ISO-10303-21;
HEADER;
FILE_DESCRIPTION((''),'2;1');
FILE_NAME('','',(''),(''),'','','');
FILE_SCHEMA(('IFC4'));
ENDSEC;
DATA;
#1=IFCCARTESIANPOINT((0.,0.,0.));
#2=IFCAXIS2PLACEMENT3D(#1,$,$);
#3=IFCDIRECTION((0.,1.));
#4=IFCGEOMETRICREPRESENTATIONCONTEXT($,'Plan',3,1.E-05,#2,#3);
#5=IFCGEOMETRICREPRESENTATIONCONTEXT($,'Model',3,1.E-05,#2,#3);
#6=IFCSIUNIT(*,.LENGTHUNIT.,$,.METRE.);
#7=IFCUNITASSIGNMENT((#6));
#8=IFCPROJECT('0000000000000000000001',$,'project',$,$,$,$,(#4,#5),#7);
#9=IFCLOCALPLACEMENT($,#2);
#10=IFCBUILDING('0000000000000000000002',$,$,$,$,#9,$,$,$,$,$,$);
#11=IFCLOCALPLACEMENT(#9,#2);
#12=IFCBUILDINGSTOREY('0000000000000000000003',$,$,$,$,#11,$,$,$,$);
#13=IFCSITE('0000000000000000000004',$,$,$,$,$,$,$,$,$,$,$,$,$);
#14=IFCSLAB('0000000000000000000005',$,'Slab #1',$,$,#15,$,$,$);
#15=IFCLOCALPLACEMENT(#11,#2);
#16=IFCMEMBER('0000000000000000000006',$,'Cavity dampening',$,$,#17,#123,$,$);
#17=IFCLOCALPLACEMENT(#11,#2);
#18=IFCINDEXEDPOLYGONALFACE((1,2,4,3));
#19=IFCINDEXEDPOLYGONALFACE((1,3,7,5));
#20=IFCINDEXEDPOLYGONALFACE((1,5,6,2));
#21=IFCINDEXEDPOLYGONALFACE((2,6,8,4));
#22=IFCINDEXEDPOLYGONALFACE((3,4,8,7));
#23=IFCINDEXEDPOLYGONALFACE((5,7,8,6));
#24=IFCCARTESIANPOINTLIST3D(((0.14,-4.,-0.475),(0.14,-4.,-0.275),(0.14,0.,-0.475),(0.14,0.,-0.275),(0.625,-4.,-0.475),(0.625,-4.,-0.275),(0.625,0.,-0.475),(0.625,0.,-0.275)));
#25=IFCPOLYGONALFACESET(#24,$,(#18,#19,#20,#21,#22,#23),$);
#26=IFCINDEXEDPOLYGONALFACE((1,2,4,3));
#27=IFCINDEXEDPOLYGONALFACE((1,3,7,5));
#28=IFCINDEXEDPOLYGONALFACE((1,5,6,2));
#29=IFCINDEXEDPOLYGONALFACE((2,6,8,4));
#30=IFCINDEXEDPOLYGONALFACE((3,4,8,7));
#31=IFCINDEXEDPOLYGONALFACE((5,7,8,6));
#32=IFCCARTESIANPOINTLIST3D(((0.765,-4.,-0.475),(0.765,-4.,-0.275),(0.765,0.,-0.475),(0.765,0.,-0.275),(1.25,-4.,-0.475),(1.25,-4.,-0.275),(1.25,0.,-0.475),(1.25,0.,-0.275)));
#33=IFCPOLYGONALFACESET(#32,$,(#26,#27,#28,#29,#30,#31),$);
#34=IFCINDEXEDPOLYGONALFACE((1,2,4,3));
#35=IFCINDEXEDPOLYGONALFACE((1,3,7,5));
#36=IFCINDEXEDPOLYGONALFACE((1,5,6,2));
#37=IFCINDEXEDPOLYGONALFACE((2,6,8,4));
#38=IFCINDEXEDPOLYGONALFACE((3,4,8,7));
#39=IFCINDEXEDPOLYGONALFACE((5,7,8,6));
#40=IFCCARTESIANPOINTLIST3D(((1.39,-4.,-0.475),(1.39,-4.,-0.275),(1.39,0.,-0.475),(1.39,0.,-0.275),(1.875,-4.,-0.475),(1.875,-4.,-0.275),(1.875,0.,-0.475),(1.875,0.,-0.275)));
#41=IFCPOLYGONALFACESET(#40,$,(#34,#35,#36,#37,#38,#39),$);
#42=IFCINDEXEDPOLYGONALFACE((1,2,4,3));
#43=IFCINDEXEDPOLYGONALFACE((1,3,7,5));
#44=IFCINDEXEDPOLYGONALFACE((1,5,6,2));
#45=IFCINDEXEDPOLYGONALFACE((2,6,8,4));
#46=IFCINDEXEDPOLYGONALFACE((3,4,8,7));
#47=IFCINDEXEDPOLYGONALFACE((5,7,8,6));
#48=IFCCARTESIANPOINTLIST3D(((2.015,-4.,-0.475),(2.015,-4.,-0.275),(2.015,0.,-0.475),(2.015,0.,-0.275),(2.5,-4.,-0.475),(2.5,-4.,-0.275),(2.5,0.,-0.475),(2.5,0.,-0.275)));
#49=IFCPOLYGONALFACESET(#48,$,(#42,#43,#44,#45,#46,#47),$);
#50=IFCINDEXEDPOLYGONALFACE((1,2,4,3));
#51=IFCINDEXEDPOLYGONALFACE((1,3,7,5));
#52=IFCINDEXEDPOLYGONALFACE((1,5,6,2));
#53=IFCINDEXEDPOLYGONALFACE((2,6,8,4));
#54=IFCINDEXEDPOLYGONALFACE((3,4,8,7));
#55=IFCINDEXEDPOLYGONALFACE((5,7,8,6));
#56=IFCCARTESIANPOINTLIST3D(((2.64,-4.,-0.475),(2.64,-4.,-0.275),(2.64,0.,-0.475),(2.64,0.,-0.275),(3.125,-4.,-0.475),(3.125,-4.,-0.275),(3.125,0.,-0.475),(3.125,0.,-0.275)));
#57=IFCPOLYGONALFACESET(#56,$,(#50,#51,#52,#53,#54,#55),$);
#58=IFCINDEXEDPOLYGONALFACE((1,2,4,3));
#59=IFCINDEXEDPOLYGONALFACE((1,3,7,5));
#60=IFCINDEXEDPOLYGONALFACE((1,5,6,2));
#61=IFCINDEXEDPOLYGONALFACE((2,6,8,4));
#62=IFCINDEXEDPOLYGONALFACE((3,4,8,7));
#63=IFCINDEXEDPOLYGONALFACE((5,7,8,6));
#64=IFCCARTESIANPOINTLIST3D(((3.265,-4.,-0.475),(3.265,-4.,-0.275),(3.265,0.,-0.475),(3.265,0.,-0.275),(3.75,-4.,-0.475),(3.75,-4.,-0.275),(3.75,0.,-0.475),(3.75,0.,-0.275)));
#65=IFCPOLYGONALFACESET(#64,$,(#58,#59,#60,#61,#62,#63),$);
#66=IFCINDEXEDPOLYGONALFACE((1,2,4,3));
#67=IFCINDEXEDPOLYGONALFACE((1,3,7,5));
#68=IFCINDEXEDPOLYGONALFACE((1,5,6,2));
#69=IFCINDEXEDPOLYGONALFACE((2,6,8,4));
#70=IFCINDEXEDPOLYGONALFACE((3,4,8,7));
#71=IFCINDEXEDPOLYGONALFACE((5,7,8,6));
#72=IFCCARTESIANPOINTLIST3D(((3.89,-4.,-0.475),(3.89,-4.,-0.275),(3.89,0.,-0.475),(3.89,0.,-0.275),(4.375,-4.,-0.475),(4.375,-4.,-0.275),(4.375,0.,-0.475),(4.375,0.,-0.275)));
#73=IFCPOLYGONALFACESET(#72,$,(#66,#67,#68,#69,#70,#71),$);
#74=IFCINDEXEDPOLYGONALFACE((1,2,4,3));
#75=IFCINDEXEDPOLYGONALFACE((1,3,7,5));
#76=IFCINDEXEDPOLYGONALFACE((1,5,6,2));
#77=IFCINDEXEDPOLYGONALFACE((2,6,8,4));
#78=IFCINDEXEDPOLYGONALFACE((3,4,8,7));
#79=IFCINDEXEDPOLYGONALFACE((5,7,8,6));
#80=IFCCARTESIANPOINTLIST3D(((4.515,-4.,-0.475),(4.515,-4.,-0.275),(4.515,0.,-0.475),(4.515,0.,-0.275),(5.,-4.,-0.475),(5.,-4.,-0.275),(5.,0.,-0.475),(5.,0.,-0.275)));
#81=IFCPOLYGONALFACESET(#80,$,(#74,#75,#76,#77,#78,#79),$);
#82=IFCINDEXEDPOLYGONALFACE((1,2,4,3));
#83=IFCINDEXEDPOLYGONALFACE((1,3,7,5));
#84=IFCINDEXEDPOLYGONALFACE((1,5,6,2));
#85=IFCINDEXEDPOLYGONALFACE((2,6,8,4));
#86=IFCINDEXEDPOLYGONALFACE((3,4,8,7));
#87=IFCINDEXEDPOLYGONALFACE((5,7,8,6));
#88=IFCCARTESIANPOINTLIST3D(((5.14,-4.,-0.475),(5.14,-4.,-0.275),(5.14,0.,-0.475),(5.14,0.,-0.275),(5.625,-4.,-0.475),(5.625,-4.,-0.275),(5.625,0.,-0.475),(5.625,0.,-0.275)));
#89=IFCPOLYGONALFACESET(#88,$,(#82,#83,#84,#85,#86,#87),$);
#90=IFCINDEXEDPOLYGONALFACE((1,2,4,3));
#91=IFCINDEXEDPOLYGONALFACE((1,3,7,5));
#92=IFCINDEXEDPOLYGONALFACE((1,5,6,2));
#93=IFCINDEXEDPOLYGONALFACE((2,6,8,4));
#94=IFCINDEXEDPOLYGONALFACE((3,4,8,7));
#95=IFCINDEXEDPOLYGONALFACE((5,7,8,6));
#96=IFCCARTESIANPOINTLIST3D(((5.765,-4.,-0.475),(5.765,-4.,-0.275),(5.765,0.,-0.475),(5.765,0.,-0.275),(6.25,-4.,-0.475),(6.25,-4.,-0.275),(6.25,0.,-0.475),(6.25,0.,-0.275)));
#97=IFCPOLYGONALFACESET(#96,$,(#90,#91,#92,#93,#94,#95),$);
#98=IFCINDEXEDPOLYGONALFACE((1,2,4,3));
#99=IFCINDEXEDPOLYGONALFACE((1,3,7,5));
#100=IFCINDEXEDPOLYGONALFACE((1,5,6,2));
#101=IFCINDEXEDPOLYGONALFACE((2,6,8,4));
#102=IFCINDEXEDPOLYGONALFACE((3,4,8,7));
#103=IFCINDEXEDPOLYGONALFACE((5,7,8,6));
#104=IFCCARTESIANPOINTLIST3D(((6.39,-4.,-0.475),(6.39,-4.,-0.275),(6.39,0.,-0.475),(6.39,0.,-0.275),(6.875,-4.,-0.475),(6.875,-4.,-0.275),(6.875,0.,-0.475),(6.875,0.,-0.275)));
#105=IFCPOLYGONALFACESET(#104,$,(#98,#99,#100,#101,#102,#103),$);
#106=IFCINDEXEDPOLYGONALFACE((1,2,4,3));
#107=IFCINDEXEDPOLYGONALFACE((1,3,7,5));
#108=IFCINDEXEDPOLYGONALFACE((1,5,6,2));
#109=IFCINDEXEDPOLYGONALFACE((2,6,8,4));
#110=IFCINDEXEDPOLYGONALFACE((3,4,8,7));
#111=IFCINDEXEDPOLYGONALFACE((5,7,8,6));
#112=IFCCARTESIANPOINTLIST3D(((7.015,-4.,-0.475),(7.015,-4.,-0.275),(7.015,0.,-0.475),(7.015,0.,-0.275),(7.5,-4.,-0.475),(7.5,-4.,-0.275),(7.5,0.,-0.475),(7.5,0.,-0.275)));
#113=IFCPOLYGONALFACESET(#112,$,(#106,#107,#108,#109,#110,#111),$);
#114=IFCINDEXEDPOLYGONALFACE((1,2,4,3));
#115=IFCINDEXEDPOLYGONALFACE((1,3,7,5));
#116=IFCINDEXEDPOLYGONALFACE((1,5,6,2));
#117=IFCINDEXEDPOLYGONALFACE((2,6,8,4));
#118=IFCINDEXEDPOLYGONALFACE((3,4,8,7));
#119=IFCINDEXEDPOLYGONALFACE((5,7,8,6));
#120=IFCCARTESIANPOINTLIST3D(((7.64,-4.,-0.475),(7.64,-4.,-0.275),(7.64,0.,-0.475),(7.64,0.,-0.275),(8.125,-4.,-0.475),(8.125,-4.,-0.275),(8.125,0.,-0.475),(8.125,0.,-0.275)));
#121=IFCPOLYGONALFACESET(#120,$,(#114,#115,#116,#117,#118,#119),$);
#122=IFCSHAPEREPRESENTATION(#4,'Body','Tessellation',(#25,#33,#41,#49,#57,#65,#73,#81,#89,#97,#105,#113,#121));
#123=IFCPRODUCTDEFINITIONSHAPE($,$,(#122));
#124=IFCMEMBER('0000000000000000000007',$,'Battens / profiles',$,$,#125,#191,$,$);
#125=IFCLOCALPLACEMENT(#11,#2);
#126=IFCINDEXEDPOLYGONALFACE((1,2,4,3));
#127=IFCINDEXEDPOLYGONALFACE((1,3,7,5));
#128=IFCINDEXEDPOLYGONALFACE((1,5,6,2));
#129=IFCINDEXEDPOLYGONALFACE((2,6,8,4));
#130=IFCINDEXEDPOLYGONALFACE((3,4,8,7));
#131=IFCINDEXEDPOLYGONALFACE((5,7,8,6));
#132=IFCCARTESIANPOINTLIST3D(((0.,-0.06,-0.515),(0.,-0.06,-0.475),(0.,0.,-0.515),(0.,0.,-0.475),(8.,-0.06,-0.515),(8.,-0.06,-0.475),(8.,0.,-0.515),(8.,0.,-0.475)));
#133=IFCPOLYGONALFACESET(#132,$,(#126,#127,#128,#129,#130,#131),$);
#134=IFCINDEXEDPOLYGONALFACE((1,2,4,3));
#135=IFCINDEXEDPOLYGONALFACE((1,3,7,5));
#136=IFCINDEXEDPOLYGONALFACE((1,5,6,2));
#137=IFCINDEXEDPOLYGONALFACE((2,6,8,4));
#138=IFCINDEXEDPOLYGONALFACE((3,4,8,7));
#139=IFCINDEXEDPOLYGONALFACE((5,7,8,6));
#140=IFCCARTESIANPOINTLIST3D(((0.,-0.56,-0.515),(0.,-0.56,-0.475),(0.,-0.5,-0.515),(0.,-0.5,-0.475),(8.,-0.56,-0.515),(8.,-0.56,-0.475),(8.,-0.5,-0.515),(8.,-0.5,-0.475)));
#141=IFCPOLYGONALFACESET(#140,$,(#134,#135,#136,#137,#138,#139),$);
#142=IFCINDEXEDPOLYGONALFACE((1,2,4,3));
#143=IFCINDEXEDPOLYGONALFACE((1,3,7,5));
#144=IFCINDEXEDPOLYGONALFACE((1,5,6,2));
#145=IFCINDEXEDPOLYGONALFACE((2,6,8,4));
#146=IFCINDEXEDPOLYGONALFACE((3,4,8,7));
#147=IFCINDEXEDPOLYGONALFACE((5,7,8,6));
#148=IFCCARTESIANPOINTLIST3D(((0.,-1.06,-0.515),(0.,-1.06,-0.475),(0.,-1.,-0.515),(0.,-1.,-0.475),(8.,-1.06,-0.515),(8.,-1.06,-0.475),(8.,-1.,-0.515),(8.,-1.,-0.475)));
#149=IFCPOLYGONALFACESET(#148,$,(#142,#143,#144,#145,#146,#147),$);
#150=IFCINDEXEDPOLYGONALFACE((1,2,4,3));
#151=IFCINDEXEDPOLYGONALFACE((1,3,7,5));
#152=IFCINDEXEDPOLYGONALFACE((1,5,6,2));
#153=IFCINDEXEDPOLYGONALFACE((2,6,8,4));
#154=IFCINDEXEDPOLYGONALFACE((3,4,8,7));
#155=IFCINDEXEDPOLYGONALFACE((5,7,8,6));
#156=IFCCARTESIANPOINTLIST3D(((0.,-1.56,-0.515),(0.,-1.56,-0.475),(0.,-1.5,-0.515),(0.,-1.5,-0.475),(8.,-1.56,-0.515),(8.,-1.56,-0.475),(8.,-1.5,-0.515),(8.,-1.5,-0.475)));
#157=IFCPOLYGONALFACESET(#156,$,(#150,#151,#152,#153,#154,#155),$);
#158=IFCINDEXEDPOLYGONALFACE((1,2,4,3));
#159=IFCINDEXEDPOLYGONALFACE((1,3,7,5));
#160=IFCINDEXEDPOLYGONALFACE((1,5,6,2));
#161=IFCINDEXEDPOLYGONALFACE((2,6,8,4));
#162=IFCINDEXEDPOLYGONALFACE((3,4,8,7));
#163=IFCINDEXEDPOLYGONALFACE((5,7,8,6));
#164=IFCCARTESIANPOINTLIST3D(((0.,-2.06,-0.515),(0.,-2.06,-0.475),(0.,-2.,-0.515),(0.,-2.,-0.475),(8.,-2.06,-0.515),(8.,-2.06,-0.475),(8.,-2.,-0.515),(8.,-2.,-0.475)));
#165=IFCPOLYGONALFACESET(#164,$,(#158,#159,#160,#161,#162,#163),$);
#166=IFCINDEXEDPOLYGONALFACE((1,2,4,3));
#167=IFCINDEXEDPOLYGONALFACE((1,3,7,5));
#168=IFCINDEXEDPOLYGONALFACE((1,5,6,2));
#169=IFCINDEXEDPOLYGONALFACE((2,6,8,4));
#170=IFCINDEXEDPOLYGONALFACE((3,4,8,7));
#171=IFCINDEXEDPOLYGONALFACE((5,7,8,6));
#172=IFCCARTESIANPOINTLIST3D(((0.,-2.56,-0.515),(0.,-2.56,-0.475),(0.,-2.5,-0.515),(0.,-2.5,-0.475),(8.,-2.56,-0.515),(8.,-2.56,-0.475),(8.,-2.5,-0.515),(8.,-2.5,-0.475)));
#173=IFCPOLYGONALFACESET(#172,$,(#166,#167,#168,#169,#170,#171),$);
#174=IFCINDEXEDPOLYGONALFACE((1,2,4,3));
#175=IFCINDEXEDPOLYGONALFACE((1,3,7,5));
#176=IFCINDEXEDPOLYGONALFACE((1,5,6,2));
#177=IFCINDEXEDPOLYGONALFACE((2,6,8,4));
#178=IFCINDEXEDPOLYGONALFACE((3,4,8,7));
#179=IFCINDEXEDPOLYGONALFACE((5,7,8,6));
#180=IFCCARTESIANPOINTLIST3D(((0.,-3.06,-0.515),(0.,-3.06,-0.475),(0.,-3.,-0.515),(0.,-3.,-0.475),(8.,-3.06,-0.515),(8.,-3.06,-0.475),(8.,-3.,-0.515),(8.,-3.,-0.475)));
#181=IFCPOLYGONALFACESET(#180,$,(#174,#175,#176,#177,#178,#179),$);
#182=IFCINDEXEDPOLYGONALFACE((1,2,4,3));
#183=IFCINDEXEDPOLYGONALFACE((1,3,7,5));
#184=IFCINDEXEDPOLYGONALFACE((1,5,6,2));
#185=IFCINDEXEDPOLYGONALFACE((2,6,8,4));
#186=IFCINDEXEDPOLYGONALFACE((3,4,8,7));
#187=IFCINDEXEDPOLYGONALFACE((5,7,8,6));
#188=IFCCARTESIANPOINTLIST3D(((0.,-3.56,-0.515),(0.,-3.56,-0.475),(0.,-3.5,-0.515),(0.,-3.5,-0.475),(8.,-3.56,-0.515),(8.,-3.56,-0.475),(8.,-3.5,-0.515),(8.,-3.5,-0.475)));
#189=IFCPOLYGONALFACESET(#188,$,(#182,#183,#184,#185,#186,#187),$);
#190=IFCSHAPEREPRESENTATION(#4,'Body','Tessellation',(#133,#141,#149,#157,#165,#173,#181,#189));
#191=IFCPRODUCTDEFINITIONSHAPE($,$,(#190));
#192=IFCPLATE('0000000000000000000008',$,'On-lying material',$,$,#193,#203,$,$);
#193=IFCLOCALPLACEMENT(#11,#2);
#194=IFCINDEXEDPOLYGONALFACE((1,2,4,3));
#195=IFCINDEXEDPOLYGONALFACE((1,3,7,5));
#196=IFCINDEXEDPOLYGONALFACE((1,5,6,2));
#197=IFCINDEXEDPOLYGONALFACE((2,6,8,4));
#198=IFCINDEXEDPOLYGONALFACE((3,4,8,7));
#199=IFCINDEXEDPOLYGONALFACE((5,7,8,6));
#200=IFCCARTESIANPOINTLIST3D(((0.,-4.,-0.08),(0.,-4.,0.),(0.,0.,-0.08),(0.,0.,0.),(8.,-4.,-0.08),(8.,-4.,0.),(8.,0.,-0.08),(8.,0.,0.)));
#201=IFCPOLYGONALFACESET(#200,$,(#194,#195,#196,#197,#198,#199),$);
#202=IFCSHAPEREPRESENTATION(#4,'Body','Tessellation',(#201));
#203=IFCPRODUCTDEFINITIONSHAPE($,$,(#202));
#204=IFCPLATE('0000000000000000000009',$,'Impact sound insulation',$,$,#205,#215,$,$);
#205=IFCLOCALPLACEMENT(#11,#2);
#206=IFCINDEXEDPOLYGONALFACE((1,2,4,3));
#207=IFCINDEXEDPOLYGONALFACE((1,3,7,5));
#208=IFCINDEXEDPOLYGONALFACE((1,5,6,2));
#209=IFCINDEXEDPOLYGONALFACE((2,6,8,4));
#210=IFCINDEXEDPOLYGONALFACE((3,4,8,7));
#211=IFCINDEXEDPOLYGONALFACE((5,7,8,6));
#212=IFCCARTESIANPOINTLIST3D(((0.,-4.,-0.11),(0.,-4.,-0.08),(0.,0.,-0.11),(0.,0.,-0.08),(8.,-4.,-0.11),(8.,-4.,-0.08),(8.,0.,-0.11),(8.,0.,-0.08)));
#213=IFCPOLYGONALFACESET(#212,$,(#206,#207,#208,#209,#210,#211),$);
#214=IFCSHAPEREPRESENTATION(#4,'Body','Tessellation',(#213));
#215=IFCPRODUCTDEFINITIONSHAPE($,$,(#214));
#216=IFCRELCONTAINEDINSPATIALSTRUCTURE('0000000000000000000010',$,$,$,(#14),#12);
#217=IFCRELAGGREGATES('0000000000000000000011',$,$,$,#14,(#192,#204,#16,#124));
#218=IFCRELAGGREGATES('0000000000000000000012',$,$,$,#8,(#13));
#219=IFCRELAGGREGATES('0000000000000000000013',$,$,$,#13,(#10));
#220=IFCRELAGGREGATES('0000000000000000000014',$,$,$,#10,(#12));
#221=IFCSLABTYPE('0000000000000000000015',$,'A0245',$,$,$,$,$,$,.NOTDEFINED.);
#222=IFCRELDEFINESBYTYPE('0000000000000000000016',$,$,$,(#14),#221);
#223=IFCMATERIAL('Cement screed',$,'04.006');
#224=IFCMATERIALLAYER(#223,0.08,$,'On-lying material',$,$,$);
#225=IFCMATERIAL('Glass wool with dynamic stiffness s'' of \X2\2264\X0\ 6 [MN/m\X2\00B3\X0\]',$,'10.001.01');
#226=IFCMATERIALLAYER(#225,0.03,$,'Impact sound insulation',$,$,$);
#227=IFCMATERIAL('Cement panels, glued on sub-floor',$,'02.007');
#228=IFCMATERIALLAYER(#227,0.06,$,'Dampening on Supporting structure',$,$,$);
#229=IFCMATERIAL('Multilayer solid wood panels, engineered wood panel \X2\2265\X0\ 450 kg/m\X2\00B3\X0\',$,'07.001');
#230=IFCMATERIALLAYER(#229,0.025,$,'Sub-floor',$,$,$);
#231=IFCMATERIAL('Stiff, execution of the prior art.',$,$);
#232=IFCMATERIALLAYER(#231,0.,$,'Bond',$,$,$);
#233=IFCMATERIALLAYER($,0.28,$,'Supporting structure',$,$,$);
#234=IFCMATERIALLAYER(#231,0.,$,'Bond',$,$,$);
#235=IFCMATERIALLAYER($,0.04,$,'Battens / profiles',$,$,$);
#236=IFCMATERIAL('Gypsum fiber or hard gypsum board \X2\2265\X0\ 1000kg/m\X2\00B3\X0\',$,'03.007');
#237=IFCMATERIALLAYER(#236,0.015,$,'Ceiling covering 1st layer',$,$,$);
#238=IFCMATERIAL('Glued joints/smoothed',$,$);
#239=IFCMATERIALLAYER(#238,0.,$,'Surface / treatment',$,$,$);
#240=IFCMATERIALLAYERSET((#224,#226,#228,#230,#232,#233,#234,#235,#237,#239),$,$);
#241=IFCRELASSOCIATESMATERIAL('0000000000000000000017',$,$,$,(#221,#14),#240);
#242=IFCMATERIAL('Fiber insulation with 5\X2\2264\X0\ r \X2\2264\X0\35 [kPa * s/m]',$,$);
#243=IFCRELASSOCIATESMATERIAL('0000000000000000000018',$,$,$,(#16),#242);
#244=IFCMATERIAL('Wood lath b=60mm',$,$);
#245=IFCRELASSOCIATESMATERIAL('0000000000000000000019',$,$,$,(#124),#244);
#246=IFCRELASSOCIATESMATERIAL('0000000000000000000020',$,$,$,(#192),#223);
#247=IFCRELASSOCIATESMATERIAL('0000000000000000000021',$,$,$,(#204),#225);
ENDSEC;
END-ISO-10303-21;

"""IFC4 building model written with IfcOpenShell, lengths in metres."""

from ifc_helpers import new_model, si_unit, direction, frame, frame_2d, origin, origin_with_axes, place, context, project, spatial, rectangle, extrude, material, layer, layer_set, type_object, element, aggregate, save


model = new_model("IFC4")

# Units and contexts
plan_context = context("Plan", 3, precision=1e-05, world=origin(), true_north=direction((0.0, 1.0)))
model_context = context("Model", 3, precision=1e-05, world=origin(), true_north=direction((0.0, 1.0)))
ifc_project = project(units=[si_unit("LENGTHUNIT", "METRE")], contexts=[plan_context, model_context])

# Site, building, storey
site = spatial("IfcSite", under=ifc_project)
building_placement = place(None, origin())
building = spatial("IfcBuilding", under=site, at=building_placement)
storey_placement = place(building_placement, origin())
storey = spatial("IfcBuildingStorey", under=building, at=storey_placement)

# Slab, members, plates
ifc_material_1 = material(Name="Cement screed", Category="04.006")
ifc_layer_1 = layer(ifc_material_1, 0.08, Name="On-lying material")
ifc_material_2 = material(Name="Glass wool with dynamic stiffness s' of ≤ 6 [MN/m³]", Category="10.001.01")
ifc_layer_2 = layer(ifc_material_2, 0.03, Name="Impact sound insulation")
ifc_material_3 = material(Name="Cement panels, glued on sub-floor", Category="02.007")
ifc_layer_3 = layer(ifc_material_3, 0.06, Name="Dampening on Supporting structure")
ifc_material_4 = material(Name="Multilayer solid wood panels, engineered wood panel ≥ 450 kg/m³", Category="07.001")
ifc_layer_4 = layer(ifc_material_4, 0.025, Name="Sub-floor")
ifc_material_5 = material(Name="Stiff, execution of the prior art.")
ifc_layer_5 = layer(ifc_material_5, 0.0, Name="Bond")
ifc_layer_6 = layer(None, 0.28, Name="Supporting structure")
ifc_layer_7 = layer(ifc_material_5, 0.0, Name="Bond")
ifc_layer_8 = layer(None, 0.04, Name="Battens / profiles")
ifc_material_6 = material(Name="Gypsum fiber or hard gypsum board ≥ 1000kg/m³", Category="03.007")
ifc_layer_9 = layer(ifc_material_6, 0.015, Name="Ceiling covering 1st layer")
ifc_material_7 = material(Name="Glued joints/smoothed")
ifc_layer_10 = layer(ifc_material_7, 0.0, Name="Surface / treatment")
ifc_layer_set = layer_set([ifc_layer_1, ifc_layer_2, ifc_layer_3, ifc_layer_4, ifc_layer_5, ifc_layer_6, ifc_layer_7, ifc_layer_8, ifc_layer_9, ifc_layer_10])
slab_type = type_object("IfcSlabType", Name="A0245", PredefinedType="NOTDEFINED", material=ifc_layer_set)
slab_placement = place(None, frame((0.0, 0.0, 0.0), z_axis=(0.0, 0.0, -1.0), x_axis=(1.0, 0.0, 0.0)))
slab = element("IfcSlab", 1, at=slab_placement, inside=storey, type_object=slab_type, material=ifc_layer_set, Name="Slab #1")
ifc_material_8 = material(Name="Fiber insulation with 5≤ r ≤35 [kPa * s/m]")
member_1_placement = place(slab_placement, origin())
member_1 = element("IfcMember", 2, at=member_1_placement, material=ifc_material_8, Name="Cavity dampening", context=plan_context, shape_type="SweptSolid", body=[
    extrude(rectangle(XDim=0.485, YDim=0.2, at=frame_2d((0.2425, 0.1), x_axis=(1.0, 0.0))), frame((0.14, 4.0, 0.275), z_axis=(0.0, -1.0, 0.0), x_axis=(1.0, 0.0, 0.0)), (0.0, 0.0, 1.0), 4.0),
    extrude(rectangle(XDim=0.485, YDim=0.2, at=frame_2d((0.2425, 0.1), x_axis=(1.0, 0.0))), frame((0.765, 4.0, 0.275), z_axis=(0.0, -1.0, 0.0), x_axis=(1.0, 0.0, 0.0)), (0.0, 0.0, 1.0), 4.0),
    extrude(rectangle(XDim=0.485, YDim=0.2, at=frame_2d((0.2425, 0.1), x_axis=(1.0, 0.0))), frame((1.39, 4.0, 0.275), z_axis=(0.0, -1.0, 0.0), x_axis=(1.0, 0.0, 0.0)), (0.0, 0.0, 1.0), 4.0),
    extrude(rectangle(XDim=0.485, YDim=0.2, at=frame_2d((0.2425, 0.1), x_axis=(1.0, 0.0))), frame((2.015, 4.0, 0.275), z_axis=(0.0, -1.0, 0.0), x_axis=(1.0, 0.0, 0.0)), (0.0, 0.0, 1.0), 4.0),
    extrude(rectangle(XDim=0.485, YDim=0.2, at=frame_2d((0.2425, 0.1), x_axis=(1.0, 0.0))), frame((2.64, 4.0, 0.275), z_axis=(0.0, -1.0, 0.0), x_axis=(1.0, 0.0, 0.0)), (0.0, 0.0, 1.0), 4.0),
    extrude(rectangle(XDim=0.485, YDim=0.2, at=frame_2d((0.2425, 0.1), x_axis=(1.0, 0.0))), frame((3.265, 4.0, 0.275), z_axis=(0.0, -1.0, 0.0), x_axis=(1.0, 0.0, 0.0)), (0.0, 0.0, 1.0), 4.0),
    extrude(rectangle(XDim=0.485, YDim=0.2, at=frame_2d((0.2425, 0.1), x_axis=(1.0, 0.0))), frame((3.89, 4.0, 0.275), z_axis=(0.0, -1.0, 0.0), x_axis=(1.0, 0.0, 0.0)), (0.0, 0.0, 1.0), 4.0),
    extrude(rectangle(XDim=0.485, YDim=0.2, at=frame_2d((0.2425, 0.1), x_axis=(1.0, 0.0))), frame((4.515, 4.0, 0.275), z_axis=(0.0, -1.0, 0.0), x_axis=(1.0, 0.0, 0.0)), (0.0, 0.0, 1.0), 4.0),
    extrude(rectangle(XDim=0.485, YDim=0.2, at=frame_2d((0.2425, 0.1), x_axis=(1.0, 0.0))), frame((5.14, 4.0, 0.275), z_axis=(0.0, -1.0, 0.0), x_axis=(1.0, 0.0, 0.0)), (0.0, 0.0, 1.0), 4.0),
    extrude(rectangle(XDim=0.485, YDim=0.2, at=frame_2d((0.2425, 0.1), x_axis=(1.0, 0.0))), frame((5.765, 4.0, 0.275), z_axis=(0.0, -1.0, 0.0), x_axis=(1.0, 0.0, 0.0)), (0.0, 0.0, 1.0), 4.0),
    extrude(rectangle(XDim=0.485, YDim=0.2, at=frame_2d((0.2425, 0.1), x_axis=(1.0, 0.0))), frame((6.39, 4.0, 0.275), z_axis=(0.0, -1.0, 0.0), x_axis=(1.0, 0.0, 0.0)), (0.0, 0.0, 1.0), 4.0),
    extrude(rectangle(XDim=0.485, YDim=0.2, at=frame_2d((0.2425, 0.1), x_axis=(1.0, 0.0))), frame((7.015, 4.0, 0.275), z_axis=(0.0, -1.0, 0.0), x_axis=(1.0, 0.0, 0.0)), (0.0, 0.0, 1.0), 4.0),
    extrude(rectangle(XDim=0.485, YDim=0.2, at=frame_2d((0.2425, 0.1), x_axis=(1.0, 0.0))), frame((7.64, 4.0, 0.275), z_axis=(0.0, -1.0, 0.0), x_axis=(1.0, 0.0, 0.0)), (0.0, 0.0, 1.0), 4.0),
])
ifc_material_9 = material(Name="Wood lath b=60mm")
member_2_placement = place(slab_placement, origin())
member_2 = element("IfcMember", 3, at=member_2_placement, material=ifc_material_9, Name="Battens / profiles", context=plan_context, shape_type="SweptSolid", body=[
    extrude(rectangle(XDim=0.06, YDim=0.04, at=frame_2d((0.03, 0.02), x_axis=(1.0, 0.0))), frame((0.0, 0.0, 0.475), z_axis=(1.0, 0.0, 0.0), x_axis=(0.0, 1.0, 0.0)), (0.0, 0.0, 1.0), 8.0),
    extrude(rectangle(XDim=0.06, YDim=0.04, at=frame_2d((0.03, 0.02), x_axis=(1.0, 0.0))), frame((0.0, 0.5, 0.475), z_axis=(1.0, 0.0, 0.0), x_axis=(0.0, 1.0, 0.0)), (0.0, 0.0, 1.0), 8.0),
    extrude(rectangle(XDim=0.06, YDim=0.04, at=frame_2d((0.03, 0.02), x_axis=(1.0, 0.0))), frame((0.0, 1.0, 0.475), z_axis=(1.0, 0.0, 0.0), x_axis=(0.0, 1.0, 0.0)), (0.0, 0.0, 1.0), 8.0),
    extrude(rectangle(XDim=0.06, YDim=0.04, at=frame_2d((0.03, 0.02), x_axis=(1.0, 0.0))), frame((0.0, 1.5, 0.475), z_axis=(1.0, 0.0, 0.0), x_axis=(0.0, 1.0, 0.0)), (0.0, 0.0, 1.0), 8.0),
    extrude(rectangle(XDim=0.06, YDim=0.04, at=frame_2d((0.03, 0.02), x_axis=(1.0, 0.0))), frame((0.0, 2.0, 0.475), z_axis=(1.0, 0.0, 0.0), x_axis=(0.0, 1.0, 0.0)), (0.0, 0.0, 1.0), 8.0),
    extrude(rectangle(XDim=0.06, YDim=0.04, at=frame_2d((0.03, 0.02), x_axis=(1.0, 0.0))), frame((0.0, 2.5, 0.475), z_axis=(1.0, 0.0, 0.0), x_axis=(0.0, 1.0, 0.0)), (0.0, 0.0, 1.0), 8.0),
    extrude(rectangle(XDim=0.06, YDim=0.04, at=frame_2d((0.03, 0.02), x_axis=(1.0, 0.0))), frame((0.0, 3.0, 0.475), z_axis=(1.0, 0.0, 0.0), x_axis=(0.0, 1.0, 0.0)), (0.0, 0.0, 1.0), 8.0),
    extrude(rectangle(XDim=0.06, YDim=0.04, at=frame_2d((0.03, 0.02), x_axis=(1.0, 0.0))), frame((0.0, 3.5, 0.475), z_axis=(1.0, 0.0, 0.0), x_axis=(0.0, 1.0, 0.0)), (0.0, 0.0, 1.0), 8.0),
])
plate_1_placement = place(slab_placement, origin())
plate_1 = element("IfcPlate", 4, at=plate_1_placement, material=ifc_material_1, Name="On-lying material", context=plan_context, shape_type="SweptSolid", body=[
    extrude(rectangle(XDim=8.0, YDim=4.0, at=frame_2d((4.0, 2.0), x_axis=(1.0, 0.0))), origin_with_axes(), (0.0, 0.0, 1.0), 0.08),
])
plate_2_placement = place(slab_placement, origin())
plate_2 = element("IfcPlate", 5, at=plate_2_placement, material=ifc_material_2, Name="Impact sound insulation", context=plan_context, shape_type="SweptSolid", body=[
    extrude(rectangle(XDim=8.0, YDim=4.0, at=frame_2d((4.0, 2.0), x_axis=(1.0, 0.0))), frame((0.0, 0.0, 0.08), z_axis=(0.0, 0.0, 1.0), x_axis=(1.0, 0.0, 0.0)), (0.0, 0.0, 1.0), 0.03),
])
aggregate(slab, [plate_1, plate_2, member_1, member_2])

save(model, "model.ifc")
